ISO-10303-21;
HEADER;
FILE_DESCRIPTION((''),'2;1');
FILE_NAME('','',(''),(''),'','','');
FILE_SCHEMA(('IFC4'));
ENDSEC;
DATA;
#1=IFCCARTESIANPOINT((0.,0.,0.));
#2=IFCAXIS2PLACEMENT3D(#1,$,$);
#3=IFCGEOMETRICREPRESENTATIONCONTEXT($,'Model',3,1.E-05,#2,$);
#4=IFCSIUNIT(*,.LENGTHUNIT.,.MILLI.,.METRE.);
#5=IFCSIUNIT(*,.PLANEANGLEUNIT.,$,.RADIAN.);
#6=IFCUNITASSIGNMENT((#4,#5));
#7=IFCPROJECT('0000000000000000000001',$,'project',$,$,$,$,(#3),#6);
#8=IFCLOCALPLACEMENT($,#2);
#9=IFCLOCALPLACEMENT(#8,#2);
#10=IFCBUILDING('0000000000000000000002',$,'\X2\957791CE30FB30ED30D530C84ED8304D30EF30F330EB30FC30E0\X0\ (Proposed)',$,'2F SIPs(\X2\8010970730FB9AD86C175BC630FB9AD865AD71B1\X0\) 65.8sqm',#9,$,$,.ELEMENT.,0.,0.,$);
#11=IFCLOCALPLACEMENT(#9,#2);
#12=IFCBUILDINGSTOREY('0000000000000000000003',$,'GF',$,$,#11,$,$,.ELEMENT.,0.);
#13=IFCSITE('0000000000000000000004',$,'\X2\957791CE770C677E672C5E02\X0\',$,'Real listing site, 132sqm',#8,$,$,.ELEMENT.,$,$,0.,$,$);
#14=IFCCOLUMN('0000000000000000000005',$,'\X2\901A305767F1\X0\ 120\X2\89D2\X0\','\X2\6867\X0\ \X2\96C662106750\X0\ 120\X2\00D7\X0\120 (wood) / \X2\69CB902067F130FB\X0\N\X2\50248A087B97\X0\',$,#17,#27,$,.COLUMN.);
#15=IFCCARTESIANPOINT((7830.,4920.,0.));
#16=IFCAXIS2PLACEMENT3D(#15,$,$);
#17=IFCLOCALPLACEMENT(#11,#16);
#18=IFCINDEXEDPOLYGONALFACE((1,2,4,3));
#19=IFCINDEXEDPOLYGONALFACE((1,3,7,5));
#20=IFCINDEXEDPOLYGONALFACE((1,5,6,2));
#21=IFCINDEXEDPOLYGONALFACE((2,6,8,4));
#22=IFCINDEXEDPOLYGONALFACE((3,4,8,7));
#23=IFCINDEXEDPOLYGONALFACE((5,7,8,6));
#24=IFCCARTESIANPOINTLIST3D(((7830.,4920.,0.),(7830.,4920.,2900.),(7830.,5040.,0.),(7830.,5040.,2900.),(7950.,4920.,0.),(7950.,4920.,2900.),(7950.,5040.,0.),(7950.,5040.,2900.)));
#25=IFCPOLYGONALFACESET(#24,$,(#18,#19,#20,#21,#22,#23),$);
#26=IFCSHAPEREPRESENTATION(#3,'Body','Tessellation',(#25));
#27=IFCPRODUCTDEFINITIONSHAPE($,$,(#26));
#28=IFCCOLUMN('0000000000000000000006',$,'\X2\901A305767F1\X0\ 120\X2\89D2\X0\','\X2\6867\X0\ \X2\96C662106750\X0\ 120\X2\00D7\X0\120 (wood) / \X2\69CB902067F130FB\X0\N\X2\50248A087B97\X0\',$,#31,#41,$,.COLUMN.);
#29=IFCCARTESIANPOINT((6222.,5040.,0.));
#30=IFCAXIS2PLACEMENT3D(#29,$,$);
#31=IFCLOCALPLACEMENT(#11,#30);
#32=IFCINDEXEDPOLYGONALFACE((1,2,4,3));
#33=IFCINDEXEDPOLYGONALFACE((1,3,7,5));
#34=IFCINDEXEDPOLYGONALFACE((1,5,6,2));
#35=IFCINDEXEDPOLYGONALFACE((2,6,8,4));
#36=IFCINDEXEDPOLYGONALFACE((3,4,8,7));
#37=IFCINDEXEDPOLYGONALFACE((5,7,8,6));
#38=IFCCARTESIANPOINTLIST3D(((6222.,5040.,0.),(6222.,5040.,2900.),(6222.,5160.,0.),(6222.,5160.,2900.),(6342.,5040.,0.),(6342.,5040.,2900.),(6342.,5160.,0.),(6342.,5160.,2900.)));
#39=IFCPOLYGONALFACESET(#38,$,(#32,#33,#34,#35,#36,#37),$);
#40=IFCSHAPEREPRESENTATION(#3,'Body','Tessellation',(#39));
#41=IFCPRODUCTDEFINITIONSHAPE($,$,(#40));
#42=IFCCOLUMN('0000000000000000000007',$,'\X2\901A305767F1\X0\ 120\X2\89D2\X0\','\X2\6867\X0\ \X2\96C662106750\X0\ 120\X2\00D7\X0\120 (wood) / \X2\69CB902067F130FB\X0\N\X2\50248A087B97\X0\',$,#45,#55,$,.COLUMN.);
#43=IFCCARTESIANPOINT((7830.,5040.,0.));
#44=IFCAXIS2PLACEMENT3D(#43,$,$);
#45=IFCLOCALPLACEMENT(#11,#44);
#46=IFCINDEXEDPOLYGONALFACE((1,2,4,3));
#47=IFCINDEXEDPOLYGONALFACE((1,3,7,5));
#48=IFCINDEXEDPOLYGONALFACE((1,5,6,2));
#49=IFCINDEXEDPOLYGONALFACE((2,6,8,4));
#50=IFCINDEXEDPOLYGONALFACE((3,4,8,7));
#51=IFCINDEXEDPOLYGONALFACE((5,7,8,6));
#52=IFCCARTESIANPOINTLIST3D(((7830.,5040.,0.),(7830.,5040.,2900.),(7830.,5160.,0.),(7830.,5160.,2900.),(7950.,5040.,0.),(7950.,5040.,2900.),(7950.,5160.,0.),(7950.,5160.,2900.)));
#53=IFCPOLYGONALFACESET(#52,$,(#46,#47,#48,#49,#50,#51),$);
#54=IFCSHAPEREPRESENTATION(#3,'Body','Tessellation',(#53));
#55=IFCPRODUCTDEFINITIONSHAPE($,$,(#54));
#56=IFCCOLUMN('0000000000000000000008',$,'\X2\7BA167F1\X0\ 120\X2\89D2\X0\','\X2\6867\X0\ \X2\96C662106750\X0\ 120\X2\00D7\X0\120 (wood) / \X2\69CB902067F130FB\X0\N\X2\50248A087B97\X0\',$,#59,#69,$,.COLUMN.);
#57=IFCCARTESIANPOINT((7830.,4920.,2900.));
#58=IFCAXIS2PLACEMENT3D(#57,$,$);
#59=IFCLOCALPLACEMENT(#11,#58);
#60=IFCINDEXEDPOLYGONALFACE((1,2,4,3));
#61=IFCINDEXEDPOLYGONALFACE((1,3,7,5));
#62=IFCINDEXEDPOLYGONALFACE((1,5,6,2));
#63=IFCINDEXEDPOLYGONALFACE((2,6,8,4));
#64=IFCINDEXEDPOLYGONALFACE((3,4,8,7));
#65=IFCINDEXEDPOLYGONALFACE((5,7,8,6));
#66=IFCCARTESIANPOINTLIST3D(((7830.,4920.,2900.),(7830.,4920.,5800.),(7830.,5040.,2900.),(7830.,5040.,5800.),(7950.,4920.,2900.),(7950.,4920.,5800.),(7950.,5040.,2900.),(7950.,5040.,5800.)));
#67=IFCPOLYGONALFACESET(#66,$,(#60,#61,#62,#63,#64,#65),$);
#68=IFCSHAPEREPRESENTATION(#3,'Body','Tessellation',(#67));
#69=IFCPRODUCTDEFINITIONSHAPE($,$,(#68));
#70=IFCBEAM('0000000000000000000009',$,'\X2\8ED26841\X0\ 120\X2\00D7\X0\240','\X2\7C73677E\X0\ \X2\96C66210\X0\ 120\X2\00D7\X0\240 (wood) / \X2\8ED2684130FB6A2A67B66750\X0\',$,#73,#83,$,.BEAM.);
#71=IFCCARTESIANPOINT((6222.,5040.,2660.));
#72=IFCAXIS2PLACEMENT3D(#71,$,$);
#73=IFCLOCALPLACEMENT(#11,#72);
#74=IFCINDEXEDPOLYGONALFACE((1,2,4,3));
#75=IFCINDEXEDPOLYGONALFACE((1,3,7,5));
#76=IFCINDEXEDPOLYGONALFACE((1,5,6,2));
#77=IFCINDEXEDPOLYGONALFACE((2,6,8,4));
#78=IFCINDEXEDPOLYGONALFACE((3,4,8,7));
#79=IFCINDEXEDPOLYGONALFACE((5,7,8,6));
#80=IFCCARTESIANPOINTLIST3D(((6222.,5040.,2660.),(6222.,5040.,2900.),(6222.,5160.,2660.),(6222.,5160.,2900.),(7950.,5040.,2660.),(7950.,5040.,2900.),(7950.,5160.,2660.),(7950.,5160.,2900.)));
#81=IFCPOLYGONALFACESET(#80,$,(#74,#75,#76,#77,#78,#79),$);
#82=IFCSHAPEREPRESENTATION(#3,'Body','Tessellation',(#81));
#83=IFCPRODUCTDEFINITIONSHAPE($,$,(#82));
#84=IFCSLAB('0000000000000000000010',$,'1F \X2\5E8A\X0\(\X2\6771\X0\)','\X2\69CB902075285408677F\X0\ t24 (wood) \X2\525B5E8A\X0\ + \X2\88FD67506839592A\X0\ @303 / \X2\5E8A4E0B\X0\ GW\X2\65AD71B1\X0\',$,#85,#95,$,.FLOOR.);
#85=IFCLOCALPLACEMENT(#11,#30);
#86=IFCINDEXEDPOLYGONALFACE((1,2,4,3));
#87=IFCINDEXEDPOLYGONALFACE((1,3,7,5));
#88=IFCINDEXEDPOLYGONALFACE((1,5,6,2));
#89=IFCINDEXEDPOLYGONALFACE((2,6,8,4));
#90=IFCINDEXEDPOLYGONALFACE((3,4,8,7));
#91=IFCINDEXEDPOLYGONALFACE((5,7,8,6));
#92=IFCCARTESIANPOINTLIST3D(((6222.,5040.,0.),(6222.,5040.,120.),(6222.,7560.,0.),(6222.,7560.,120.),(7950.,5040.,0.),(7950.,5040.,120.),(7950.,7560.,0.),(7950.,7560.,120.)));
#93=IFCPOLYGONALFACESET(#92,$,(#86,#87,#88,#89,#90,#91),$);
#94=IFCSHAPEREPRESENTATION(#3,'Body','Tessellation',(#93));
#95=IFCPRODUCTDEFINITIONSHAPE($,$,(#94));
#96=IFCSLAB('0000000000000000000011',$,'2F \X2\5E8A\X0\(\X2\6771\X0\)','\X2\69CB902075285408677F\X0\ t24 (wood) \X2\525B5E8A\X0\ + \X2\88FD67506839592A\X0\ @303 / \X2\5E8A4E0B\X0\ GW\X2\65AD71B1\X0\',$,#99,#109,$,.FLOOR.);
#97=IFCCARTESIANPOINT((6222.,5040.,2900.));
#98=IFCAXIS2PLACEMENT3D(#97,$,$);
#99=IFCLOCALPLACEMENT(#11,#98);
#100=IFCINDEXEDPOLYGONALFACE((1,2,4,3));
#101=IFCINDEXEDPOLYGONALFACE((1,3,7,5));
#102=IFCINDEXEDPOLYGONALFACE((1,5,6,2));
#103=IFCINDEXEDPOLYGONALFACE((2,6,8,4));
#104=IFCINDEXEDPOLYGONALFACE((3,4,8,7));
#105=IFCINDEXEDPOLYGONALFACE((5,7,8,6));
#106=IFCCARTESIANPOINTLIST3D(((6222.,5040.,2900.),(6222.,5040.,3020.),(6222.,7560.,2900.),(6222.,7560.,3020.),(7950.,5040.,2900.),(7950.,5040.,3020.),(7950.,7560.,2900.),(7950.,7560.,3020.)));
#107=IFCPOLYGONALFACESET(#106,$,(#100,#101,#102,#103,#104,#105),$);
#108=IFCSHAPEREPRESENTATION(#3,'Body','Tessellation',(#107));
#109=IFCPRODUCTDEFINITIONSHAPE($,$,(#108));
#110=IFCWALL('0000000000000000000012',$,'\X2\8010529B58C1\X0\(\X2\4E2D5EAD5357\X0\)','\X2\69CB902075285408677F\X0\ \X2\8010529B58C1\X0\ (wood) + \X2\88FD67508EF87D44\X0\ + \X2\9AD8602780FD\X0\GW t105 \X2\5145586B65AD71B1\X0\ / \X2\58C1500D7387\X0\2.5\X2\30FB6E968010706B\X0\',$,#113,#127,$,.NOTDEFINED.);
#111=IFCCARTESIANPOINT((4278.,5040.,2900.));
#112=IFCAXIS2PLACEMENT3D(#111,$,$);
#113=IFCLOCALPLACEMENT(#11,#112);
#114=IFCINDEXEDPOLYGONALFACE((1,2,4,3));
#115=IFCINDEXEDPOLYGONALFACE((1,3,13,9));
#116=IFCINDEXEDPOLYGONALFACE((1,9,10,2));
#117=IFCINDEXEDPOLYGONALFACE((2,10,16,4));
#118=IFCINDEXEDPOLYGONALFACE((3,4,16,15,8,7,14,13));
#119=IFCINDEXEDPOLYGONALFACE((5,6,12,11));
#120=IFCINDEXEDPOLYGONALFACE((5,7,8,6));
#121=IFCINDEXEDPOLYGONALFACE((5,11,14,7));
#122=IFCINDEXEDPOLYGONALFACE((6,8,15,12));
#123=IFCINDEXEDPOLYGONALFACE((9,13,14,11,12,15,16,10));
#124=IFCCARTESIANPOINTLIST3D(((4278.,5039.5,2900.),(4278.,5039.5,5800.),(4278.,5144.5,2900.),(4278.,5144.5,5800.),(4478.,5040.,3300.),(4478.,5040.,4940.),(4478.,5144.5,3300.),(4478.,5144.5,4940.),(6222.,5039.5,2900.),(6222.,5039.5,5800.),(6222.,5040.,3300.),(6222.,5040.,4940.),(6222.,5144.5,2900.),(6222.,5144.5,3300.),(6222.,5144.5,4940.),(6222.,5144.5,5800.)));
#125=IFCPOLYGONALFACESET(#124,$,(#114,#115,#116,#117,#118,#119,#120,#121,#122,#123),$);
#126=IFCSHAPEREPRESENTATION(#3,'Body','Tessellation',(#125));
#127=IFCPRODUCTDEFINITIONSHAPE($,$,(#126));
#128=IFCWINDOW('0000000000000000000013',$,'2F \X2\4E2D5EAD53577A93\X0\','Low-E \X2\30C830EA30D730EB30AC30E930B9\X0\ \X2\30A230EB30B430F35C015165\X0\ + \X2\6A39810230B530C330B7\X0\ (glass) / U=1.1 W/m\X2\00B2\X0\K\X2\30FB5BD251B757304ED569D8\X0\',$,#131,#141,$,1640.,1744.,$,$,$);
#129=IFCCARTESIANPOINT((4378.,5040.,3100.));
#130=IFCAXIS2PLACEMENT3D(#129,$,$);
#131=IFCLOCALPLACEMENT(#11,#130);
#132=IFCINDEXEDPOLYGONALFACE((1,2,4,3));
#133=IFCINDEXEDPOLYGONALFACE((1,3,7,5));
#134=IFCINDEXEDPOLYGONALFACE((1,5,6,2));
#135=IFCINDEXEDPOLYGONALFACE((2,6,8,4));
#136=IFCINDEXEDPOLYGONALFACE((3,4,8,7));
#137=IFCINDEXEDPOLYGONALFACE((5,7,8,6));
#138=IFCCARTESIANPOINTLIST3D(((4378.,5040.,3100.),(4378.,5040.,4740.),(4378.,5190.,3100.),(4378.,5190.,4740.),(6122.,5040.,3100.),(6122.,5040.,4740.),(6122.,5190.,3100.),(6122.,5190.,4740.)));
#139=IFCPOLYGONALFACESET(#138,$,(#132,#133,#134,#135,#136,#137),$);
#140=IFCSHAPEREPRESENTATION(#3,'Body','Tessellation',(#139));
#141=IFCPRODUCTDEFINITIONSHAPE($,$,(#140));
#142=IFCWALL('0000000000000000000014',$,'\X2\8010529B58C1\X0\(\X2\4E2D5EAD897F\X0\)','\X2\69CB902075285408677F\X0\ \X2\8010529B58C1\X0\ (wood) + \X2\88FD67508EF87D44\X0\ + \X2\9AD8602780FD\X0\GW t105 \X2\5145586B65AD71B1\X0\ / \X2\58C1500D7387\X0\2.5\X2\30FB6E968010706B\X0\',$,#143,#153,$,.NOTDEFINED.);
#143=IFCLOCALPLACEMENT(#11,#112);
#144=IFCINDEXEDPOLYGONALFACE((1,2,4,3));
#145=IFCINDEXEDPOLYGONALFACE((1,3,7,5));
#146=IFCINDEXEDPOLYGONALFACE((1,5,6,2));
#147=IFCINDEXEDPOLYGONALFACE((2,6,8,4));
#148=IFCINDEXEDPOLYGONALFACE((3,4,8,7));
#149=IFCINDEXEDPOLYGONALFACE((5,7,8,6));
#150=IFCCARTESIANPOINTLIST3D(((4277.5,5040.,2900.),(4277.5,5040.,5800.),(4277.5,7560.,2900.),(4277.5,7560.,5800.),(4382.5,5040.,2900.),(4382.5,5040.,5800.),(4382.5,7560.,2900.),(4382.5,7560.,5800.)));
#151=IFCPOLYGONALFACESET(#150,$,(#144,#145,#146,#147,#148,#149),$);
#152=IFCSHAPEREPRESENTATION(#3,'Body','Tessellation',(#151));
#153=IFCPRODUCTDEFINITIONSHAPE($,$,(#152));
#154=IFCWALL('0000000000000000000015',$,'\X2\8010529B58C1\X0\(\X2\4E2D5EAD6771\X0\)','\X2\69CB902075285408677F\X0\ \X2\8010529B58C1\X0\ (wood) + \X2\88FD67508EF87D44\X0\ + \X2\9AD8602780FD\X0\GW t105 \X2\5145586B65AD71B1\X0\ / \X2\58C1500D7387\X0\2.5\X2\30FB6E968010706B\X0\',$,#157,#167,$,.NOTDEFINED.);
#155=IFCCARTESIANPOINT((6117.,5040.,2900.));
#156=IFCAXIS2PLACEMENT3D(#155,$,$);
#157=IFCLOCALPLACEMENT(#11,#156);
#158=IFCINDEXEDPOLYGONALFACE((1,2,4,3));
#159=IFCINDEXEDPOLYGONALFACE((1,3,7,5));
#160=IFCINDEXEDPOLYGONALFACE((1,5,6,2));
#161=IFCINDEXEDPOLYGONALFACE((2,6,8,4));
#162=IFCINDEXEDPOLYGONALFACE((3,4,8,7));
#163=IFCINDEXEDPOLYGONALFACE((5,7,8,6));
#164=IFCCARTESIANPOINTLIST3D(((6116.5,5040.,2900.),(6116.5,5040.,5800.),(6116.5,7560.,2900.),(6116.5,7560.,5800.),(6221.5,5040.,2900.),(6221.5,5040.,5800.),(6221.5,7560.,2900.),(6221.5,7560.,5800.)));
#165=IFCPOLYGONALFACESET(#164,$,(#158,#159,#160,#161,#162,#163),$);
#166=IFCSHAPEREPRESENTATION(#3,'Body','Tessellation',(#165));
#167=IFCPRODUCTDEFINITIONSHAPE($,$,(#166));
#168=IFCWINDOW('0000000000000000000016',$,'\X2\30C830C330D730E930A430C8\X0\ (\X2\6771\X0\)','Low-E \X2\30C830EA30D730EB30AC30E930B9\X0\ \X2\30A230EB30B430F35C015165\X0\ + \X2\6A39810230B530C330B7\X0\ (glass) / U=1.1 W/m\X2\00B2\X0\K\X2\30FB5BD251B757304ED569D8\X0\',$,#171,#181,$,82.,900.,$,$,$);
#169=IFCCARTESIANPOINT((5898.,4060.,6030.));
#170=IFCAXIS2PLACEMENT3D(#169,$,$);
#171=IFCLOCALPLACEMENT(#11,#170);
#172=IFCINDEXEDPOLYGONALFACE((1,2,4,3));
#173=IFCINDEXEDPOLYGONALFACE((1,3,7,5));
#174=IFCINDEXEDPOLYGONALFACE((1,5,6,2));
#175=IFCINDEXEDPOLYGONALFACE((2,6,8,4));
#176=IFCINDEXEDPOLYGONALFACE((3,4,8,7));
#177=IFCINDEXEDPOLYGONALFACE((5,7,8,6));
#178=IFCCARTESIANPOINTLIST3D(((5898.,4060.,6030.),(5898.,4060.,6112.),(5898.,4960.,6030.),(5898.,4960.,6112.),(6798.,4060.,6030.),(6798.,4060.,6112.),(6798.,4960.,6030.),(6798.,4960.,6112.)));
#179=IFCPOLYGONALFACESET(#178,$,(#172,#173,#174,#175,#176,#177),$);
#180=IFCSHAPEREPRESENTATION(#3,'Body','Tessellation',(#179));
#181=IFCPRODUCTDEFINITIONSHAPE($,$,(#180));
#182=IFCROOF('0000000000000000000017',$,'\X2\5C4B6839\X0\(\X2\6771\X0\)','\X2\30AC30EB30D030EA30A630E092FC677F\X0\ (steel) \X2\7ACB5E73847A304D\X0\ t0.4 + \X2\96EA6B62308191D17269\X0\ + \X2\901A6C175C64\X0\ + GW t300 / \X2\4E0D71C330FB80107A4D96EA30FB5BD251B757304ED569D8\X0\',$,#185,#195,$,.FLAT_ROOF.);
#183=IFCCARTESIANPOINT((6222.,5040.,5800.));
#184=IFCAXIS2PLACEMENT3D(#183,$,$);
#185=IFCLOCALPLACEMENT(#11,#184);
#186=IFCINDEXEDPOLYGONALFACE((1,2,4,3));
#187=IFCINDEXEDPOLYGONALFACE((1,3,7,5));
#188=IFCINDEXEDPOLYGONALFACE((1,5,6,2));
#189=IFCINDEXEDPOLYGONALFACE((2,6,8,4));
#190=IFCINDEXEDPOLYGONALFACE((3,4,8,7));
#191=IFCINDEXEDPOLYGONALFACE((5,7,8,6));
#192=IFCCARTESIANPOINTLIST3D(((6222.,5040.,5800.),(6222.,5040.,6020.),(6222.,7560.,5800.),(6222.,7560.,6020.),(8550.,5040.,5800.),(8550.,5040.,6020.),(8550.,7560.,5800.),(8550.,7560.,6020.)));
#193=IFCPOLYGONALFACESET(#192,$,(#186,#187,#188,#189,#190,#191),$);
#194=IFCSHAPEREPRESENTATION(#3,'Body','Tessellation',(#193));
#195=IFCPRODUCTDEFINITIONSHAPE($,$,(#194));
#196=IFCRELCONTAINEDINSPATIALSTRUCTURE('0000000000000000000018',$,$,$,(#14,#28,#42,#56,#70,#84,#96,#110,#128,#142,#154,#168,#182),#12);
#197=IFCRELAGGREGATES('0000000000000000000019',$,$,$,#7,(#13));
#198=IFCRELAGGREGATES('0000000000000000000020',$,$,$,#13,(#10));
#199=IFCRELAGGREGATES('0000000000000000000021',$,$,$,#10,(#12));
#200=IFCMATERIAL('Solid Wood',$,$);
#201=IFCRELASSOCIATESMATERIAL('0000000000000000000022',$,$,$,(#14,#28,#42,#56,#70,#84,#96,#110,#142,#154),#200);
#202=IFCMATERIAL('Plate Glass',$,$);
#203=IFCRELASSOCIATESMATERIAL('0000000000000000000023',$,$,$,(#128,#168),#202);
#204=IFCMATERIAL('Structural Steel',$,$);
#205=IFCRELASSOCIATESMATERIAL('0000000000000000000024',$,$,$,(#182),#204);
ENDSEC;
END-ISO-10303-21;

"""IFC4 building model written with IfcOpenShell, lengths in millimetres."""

from ifc_helpers import new_model, si_unit, frame, frame_2d, origin, place, context, project, spatial, rectangle, extrude, material, element, fill, save


model = new_model("IFC4")

# Units and contexts
model_context = context("Model", 3, precision=1e-05, world=origin())
ifc_project = project(units=[si_unit("LENGTHUNIT", "METRE", prefix="MILLI"), si_unit("PLANEANGLEUNIT", "RADIAN")], contexts=[model_context])

# Site, building, storey
site_placement = place(None, origin())
site = spatial("IfcSite", under=ifc_project, at=site_placement, Name="長野県松本市", ObjectType="Real listing site, 132sqm", CompositionType="ELEMENT", RefElevation=0.0)
building_placement = place(site_placement, origin())
building = spatial("IfcBuilding", under=site, at=building_placement, Name="長野・ロフト付きワンルーム (Proposed)", ObjectType="2F SIPs(耐震・高気密・高断熱) 65.8sqm", CompositionType="ELEMENT", ElevationOfRefHeight=0.0, ElevationOfTerrain=0.0)
storey_placement = place(building_placement, origin())
storey = spatial("IfcBuildingStorey", under=building, at=storey_placement, Name="GF", CompositionType="ELEMENT", Elevation=0.0)

# Columns
ifc_material_1 = material(Name="Solid Wood")
column_1_placement = place(storey_placement, frame((7830.0, 4920.0, 0.0)))
element("IfcColumn", 1, at=column_1_placement, inside=storey, material=ifc_material_1, Name="通し柱 120角", Description="桧 集成材 120×120 (wood) / 構造柱・N値計算", PredefinedType="COLUMN", context=model_context, shape_type="SweptSolid", body=[
    extrude(rectangle(XDim=120.0, YDim=120.0, at=frame_2d((60.0, 60.0))), frame((7830.0, 4920.0, 0.0)), (0.0, 0.0, 1.0), 2900.0),
])
column_2_placement = place(storey_placement, frame((6222.0, 5040.0, 0.0)))
element("IfcColumn", 2, at=column_2_placement, inside=storey, material=ifc_material_1, Name="通し柱 120角", Description="桧 集成材 120×120 (wood) / 構造柱・N値計算", PredefinedType="COLUMN", context=model_context, shape_type="SweptSolid", body=[
    extrude(rectangle(XDim=120.0, YDim=120.0, at=frame_2d((60.0, 60.0))), frame((6222.0, 5040.0, 0.0)), (0.0, 0.0, 1.0), 2900.0),
])
column_3_placement = place(storey_placement, frame((7830.0, 5040.0, 0.0)))
element("IfcColumn", 3, at=column_3_placement, inside=storey, material=ifc_material_1, Name="通し柱 120角", Description="桧 集成材 120×120 (wood) / 構造柱・N値計算", PredefinedType="COLUMN", context=model_context, shape_type="SweptSolid", body=[
    extrude(rectangle(XDim=120.0, YDim=120.0, at=frame_2d((60.0, 60.0))), frame((7830.0, 5040.0, 0.0)), (0.0, 0.0, 1.0), 2900.0),
])
column_4_placement = place(storey_placement, frame((7830.0, 4920.0, 2900.0)))
element("IfcColumn", 4, at=column_4_placement, inside=storey, material=ifc_material_1, Name="管柱 120角", Description="桧 集成材 120×120 (wood) / 構造柱・N値計算", PredefinedType="COLUMN", context=model_context, shape_type="SweptSolid", body=[
    extrude(rectangle(XDim=120.0, YDim=120.0, at=frame_2d((60.0, 60.0))), frame((7830.0, 4920.0, 2900.0)), (0.0, 0.0, 1.0), 2900.0),
])

# Beam
beam_1_placement = place(storey_placement, frame((6222.0, 5040.0, 2660.0)))
element("IfcBeam", 5, at=beam_1_placement, inside=storey, material=ifc_material_1, Name="軒桁 120×240", Description="米松 集成 120×240 (wood) / 軒桁・横架材", PredefinedType="BEAM", context=model_context, shape_type="SweptSolid", body=[
    extrude(rectangle(XDim=1728.0, YDim=120.0, at=frame_2d((864.0, 60.0))), frame((6222.0, 5040.0, 2660.0)), (0.0, 0.0, 1.0), 240.0),
])

# Slabs
slab_1_placement = place(storey_placement, frame((6222.0, 5040.0, 0.0)))
element("IfcSlab", 6, at=slab_1_placement, inside=storey, material=ifc_material_1, Name="1F 床(東)", Description="構造用合板 t24 (wood) 剛床 + 製材根太 @303 / 床下 GW断熱", PredefinedType="FLOOR", context=model_context, shape_type="SweptSolid", body=[
    extrude(rectangle(XDim=1728.0, YDim=2520.0, at=frame_2d((864.0, 1260.0))), frame((6222.0, 5040.0, 0.0)), (0.0, 0.0, 1.0), 120.0),
])
slab_2_placement = place(storey_placement, frame((6222.0, 5040.0, 2900.0)))
element("IfcSlab", 7, at=slab_2_placement, inside=storey, material=ifc_material_1, Name="2F 床(東)", Description="構造用合板 t24 (wood) 剛床 + 製材根太 @303 / 床下 GW断熱", PredefinedType="FLOOR", context=model_context, shape_type="SweptSolid", body=[
    extrude(rectangle(XDim=1728.0, YDim=2520.0, at=frame_2d((864.0, 1260.0))), frame((6222.0, 5040.0, 2900.0)), (0.0, 0.0, 1.0), 120.0),
])

# Wall, opening, window
wall_1_placement = place(storey_placement, frame((4278.0, 5040.0, 2900.0)))
wall_1 = element("IfcWall", 8, at=wall_1_placement, inside=storey, material=ifc_material_1, Name="耐力壁(中庭南)", Description="構造用合板 耐力壁 (wood) + 製材軸組 + 高性能GW t105 充填断熱 / 壁倍率2.5・準耐火", PredefinedType="NOTDEFINED", context=model_context, shape_type="SweptSolid", body=[
    extrude(rectangle(XDim=1944.0, YDim=105.0, at=frame_2d((972.0, 52.0))), frame((4278.0, 5040.0, 2900.0)), (0.0, 0.0, 1.0), 2900.0),
])
opening_placement = place(storey_placement, frame((4378.0, 5040.0, 3100.0)))
opening = element("IfcOpeningElement", 9, at=opening_placement, cuts=wall_1, PredefinedType="NOTDEFINED", context=model_context, shape_type="SweptSolid", body=[
    extrude(rectangle(XDim=1744.0, YDim=150.0, at=frame_2d((872.0, 75.0))), frame((4378.0, 5040.0, 3100.0)), (0.0, 0.0, 1.0), 1640.0),
])
ifc_material_2 = material(Name="Plate Glass")
window_1_placement = place(storey_placement, frame((4378.0, 5040.0, 3100.0)))
window_1 = element("IfcWindow", 10, at=window_1_placement, inside=storey, material=ifc_material_2, Name="2F 中庭南窓", Description="Low-E トリプルガラス アルゴン封入 + 樹脂サッシ (glass) / U=1.1 W/m²K・寒冷地仕様", OverallHeight=1640.0, OverallWidth=1744.0, context=model_context, shape_type="SweptSolid", body=[
    extrude(rectangle(XDim=1744.0, YDim=150.0, at=frame_2d((872.0, 75.0))), frame((4378.0, 5040.0, 3100.0)), (0.0, 0.0, 1.0), 1640.0),
])
fill(opening, window_1)

# Walls
wall_2_placement = place(storey_placement, frame((4278.0, 5040.0, 2900.0)))
element("IfcWall", 11, at=wall_2_placement, inside=storey, material=ifc_material_1, Name="耐力壁(中庭西)", Description="構造用合板 耐力壁 (wood) + 製材軸組 + 高性能GW t105 充填断熱 / 壁倍率2.5・準耐火", PredefinedType="NOTDEFINED", context=model_context, shape_type="SweptSolid", body=[
    extrude(rectangle(XDim=105.0, YDim=2520.0, at=frame_2d((52.0, 1260.0))), frame((4278.0, 5040.0, 2900.0)), (0.0, 0.0, 1.0), 2900.0),
])
wall_3_placement = place(storey_placement, frame((6117.0, 5040.0, 2900.0)))
element("IfcWall", 12, at=wall_3_placement, inside=storey, material=ifc_material_1, Name="耐力壁(中庭東)", Description="構造用合板 耐力壁 (wood) + 製材軸組 + 高性能GW t105 充填断熱 / 壁倍率2.5・準耐火", PredefinedType="NOTDEFINED", context=model_context, shape_type="SweptSolid", body=[
    extrude(rectangle(XDim=105.0, YDim=2520.0, at=frame_2d((52.0, 1260.0))), frame((6117.0, 5040.0, 2900.0)), (0.0, 0.0, 1.0), 2900.0),
])

# Window
window_2_placement = place(storey_placement, frame((5898.0, 4060.0, 6030.0)))
element("IfcWindow", 13, at=window_2_placement, inside=storey, material=ifc_material_2, Name="トップライト (東)", Description="Low-E トリプルガラス アルゴン封入 + 樹脂サッシ (glass) / U=1.1 W/m²K・寒冷地仕様", OverallHeight=82.0, OverallWidth=900.0, context=model_context, shape_type="SweptSolid", body=[
    extrude(rectangle(XDim=900.0, YDim=900.0, at=frame_2d((450.0, 450.0))), frame((5898.0, 4060.0, 6030.0)), (0.0, 0.0, 1.0), 82.0),
])

# Roof
ifc_material_3 = material(Name="Structural Steel")
for number, where, name in (
    (14, (6222.0, 5040.0, 5800.0), "屋根(東)"),
):
    element("IfcRoof", number, at=place(storey_placement, frame(where)), inside=storey, material=ifc_material_3, Name=name, Description="ガルバリウム鋼板 (steel) 立平葺き t0.4 + 雪止め金物 + 通気層 + GW t300 / 不燃・耐積雪・寒冷地仕様", PredefinedType="FLAT_ROOF", context=model_context, shape_type="SweptSolid", body=[
        extrude(rectangle(XDim=2328.0, YDim=2520.0, at=frame_2d((1164.0, 1260.0))), frame((6222.0, 5040.0, 5800.0)), (0.0, 0.0, 1.0), 220.0),
    ])

save(model, "model.ifc")
